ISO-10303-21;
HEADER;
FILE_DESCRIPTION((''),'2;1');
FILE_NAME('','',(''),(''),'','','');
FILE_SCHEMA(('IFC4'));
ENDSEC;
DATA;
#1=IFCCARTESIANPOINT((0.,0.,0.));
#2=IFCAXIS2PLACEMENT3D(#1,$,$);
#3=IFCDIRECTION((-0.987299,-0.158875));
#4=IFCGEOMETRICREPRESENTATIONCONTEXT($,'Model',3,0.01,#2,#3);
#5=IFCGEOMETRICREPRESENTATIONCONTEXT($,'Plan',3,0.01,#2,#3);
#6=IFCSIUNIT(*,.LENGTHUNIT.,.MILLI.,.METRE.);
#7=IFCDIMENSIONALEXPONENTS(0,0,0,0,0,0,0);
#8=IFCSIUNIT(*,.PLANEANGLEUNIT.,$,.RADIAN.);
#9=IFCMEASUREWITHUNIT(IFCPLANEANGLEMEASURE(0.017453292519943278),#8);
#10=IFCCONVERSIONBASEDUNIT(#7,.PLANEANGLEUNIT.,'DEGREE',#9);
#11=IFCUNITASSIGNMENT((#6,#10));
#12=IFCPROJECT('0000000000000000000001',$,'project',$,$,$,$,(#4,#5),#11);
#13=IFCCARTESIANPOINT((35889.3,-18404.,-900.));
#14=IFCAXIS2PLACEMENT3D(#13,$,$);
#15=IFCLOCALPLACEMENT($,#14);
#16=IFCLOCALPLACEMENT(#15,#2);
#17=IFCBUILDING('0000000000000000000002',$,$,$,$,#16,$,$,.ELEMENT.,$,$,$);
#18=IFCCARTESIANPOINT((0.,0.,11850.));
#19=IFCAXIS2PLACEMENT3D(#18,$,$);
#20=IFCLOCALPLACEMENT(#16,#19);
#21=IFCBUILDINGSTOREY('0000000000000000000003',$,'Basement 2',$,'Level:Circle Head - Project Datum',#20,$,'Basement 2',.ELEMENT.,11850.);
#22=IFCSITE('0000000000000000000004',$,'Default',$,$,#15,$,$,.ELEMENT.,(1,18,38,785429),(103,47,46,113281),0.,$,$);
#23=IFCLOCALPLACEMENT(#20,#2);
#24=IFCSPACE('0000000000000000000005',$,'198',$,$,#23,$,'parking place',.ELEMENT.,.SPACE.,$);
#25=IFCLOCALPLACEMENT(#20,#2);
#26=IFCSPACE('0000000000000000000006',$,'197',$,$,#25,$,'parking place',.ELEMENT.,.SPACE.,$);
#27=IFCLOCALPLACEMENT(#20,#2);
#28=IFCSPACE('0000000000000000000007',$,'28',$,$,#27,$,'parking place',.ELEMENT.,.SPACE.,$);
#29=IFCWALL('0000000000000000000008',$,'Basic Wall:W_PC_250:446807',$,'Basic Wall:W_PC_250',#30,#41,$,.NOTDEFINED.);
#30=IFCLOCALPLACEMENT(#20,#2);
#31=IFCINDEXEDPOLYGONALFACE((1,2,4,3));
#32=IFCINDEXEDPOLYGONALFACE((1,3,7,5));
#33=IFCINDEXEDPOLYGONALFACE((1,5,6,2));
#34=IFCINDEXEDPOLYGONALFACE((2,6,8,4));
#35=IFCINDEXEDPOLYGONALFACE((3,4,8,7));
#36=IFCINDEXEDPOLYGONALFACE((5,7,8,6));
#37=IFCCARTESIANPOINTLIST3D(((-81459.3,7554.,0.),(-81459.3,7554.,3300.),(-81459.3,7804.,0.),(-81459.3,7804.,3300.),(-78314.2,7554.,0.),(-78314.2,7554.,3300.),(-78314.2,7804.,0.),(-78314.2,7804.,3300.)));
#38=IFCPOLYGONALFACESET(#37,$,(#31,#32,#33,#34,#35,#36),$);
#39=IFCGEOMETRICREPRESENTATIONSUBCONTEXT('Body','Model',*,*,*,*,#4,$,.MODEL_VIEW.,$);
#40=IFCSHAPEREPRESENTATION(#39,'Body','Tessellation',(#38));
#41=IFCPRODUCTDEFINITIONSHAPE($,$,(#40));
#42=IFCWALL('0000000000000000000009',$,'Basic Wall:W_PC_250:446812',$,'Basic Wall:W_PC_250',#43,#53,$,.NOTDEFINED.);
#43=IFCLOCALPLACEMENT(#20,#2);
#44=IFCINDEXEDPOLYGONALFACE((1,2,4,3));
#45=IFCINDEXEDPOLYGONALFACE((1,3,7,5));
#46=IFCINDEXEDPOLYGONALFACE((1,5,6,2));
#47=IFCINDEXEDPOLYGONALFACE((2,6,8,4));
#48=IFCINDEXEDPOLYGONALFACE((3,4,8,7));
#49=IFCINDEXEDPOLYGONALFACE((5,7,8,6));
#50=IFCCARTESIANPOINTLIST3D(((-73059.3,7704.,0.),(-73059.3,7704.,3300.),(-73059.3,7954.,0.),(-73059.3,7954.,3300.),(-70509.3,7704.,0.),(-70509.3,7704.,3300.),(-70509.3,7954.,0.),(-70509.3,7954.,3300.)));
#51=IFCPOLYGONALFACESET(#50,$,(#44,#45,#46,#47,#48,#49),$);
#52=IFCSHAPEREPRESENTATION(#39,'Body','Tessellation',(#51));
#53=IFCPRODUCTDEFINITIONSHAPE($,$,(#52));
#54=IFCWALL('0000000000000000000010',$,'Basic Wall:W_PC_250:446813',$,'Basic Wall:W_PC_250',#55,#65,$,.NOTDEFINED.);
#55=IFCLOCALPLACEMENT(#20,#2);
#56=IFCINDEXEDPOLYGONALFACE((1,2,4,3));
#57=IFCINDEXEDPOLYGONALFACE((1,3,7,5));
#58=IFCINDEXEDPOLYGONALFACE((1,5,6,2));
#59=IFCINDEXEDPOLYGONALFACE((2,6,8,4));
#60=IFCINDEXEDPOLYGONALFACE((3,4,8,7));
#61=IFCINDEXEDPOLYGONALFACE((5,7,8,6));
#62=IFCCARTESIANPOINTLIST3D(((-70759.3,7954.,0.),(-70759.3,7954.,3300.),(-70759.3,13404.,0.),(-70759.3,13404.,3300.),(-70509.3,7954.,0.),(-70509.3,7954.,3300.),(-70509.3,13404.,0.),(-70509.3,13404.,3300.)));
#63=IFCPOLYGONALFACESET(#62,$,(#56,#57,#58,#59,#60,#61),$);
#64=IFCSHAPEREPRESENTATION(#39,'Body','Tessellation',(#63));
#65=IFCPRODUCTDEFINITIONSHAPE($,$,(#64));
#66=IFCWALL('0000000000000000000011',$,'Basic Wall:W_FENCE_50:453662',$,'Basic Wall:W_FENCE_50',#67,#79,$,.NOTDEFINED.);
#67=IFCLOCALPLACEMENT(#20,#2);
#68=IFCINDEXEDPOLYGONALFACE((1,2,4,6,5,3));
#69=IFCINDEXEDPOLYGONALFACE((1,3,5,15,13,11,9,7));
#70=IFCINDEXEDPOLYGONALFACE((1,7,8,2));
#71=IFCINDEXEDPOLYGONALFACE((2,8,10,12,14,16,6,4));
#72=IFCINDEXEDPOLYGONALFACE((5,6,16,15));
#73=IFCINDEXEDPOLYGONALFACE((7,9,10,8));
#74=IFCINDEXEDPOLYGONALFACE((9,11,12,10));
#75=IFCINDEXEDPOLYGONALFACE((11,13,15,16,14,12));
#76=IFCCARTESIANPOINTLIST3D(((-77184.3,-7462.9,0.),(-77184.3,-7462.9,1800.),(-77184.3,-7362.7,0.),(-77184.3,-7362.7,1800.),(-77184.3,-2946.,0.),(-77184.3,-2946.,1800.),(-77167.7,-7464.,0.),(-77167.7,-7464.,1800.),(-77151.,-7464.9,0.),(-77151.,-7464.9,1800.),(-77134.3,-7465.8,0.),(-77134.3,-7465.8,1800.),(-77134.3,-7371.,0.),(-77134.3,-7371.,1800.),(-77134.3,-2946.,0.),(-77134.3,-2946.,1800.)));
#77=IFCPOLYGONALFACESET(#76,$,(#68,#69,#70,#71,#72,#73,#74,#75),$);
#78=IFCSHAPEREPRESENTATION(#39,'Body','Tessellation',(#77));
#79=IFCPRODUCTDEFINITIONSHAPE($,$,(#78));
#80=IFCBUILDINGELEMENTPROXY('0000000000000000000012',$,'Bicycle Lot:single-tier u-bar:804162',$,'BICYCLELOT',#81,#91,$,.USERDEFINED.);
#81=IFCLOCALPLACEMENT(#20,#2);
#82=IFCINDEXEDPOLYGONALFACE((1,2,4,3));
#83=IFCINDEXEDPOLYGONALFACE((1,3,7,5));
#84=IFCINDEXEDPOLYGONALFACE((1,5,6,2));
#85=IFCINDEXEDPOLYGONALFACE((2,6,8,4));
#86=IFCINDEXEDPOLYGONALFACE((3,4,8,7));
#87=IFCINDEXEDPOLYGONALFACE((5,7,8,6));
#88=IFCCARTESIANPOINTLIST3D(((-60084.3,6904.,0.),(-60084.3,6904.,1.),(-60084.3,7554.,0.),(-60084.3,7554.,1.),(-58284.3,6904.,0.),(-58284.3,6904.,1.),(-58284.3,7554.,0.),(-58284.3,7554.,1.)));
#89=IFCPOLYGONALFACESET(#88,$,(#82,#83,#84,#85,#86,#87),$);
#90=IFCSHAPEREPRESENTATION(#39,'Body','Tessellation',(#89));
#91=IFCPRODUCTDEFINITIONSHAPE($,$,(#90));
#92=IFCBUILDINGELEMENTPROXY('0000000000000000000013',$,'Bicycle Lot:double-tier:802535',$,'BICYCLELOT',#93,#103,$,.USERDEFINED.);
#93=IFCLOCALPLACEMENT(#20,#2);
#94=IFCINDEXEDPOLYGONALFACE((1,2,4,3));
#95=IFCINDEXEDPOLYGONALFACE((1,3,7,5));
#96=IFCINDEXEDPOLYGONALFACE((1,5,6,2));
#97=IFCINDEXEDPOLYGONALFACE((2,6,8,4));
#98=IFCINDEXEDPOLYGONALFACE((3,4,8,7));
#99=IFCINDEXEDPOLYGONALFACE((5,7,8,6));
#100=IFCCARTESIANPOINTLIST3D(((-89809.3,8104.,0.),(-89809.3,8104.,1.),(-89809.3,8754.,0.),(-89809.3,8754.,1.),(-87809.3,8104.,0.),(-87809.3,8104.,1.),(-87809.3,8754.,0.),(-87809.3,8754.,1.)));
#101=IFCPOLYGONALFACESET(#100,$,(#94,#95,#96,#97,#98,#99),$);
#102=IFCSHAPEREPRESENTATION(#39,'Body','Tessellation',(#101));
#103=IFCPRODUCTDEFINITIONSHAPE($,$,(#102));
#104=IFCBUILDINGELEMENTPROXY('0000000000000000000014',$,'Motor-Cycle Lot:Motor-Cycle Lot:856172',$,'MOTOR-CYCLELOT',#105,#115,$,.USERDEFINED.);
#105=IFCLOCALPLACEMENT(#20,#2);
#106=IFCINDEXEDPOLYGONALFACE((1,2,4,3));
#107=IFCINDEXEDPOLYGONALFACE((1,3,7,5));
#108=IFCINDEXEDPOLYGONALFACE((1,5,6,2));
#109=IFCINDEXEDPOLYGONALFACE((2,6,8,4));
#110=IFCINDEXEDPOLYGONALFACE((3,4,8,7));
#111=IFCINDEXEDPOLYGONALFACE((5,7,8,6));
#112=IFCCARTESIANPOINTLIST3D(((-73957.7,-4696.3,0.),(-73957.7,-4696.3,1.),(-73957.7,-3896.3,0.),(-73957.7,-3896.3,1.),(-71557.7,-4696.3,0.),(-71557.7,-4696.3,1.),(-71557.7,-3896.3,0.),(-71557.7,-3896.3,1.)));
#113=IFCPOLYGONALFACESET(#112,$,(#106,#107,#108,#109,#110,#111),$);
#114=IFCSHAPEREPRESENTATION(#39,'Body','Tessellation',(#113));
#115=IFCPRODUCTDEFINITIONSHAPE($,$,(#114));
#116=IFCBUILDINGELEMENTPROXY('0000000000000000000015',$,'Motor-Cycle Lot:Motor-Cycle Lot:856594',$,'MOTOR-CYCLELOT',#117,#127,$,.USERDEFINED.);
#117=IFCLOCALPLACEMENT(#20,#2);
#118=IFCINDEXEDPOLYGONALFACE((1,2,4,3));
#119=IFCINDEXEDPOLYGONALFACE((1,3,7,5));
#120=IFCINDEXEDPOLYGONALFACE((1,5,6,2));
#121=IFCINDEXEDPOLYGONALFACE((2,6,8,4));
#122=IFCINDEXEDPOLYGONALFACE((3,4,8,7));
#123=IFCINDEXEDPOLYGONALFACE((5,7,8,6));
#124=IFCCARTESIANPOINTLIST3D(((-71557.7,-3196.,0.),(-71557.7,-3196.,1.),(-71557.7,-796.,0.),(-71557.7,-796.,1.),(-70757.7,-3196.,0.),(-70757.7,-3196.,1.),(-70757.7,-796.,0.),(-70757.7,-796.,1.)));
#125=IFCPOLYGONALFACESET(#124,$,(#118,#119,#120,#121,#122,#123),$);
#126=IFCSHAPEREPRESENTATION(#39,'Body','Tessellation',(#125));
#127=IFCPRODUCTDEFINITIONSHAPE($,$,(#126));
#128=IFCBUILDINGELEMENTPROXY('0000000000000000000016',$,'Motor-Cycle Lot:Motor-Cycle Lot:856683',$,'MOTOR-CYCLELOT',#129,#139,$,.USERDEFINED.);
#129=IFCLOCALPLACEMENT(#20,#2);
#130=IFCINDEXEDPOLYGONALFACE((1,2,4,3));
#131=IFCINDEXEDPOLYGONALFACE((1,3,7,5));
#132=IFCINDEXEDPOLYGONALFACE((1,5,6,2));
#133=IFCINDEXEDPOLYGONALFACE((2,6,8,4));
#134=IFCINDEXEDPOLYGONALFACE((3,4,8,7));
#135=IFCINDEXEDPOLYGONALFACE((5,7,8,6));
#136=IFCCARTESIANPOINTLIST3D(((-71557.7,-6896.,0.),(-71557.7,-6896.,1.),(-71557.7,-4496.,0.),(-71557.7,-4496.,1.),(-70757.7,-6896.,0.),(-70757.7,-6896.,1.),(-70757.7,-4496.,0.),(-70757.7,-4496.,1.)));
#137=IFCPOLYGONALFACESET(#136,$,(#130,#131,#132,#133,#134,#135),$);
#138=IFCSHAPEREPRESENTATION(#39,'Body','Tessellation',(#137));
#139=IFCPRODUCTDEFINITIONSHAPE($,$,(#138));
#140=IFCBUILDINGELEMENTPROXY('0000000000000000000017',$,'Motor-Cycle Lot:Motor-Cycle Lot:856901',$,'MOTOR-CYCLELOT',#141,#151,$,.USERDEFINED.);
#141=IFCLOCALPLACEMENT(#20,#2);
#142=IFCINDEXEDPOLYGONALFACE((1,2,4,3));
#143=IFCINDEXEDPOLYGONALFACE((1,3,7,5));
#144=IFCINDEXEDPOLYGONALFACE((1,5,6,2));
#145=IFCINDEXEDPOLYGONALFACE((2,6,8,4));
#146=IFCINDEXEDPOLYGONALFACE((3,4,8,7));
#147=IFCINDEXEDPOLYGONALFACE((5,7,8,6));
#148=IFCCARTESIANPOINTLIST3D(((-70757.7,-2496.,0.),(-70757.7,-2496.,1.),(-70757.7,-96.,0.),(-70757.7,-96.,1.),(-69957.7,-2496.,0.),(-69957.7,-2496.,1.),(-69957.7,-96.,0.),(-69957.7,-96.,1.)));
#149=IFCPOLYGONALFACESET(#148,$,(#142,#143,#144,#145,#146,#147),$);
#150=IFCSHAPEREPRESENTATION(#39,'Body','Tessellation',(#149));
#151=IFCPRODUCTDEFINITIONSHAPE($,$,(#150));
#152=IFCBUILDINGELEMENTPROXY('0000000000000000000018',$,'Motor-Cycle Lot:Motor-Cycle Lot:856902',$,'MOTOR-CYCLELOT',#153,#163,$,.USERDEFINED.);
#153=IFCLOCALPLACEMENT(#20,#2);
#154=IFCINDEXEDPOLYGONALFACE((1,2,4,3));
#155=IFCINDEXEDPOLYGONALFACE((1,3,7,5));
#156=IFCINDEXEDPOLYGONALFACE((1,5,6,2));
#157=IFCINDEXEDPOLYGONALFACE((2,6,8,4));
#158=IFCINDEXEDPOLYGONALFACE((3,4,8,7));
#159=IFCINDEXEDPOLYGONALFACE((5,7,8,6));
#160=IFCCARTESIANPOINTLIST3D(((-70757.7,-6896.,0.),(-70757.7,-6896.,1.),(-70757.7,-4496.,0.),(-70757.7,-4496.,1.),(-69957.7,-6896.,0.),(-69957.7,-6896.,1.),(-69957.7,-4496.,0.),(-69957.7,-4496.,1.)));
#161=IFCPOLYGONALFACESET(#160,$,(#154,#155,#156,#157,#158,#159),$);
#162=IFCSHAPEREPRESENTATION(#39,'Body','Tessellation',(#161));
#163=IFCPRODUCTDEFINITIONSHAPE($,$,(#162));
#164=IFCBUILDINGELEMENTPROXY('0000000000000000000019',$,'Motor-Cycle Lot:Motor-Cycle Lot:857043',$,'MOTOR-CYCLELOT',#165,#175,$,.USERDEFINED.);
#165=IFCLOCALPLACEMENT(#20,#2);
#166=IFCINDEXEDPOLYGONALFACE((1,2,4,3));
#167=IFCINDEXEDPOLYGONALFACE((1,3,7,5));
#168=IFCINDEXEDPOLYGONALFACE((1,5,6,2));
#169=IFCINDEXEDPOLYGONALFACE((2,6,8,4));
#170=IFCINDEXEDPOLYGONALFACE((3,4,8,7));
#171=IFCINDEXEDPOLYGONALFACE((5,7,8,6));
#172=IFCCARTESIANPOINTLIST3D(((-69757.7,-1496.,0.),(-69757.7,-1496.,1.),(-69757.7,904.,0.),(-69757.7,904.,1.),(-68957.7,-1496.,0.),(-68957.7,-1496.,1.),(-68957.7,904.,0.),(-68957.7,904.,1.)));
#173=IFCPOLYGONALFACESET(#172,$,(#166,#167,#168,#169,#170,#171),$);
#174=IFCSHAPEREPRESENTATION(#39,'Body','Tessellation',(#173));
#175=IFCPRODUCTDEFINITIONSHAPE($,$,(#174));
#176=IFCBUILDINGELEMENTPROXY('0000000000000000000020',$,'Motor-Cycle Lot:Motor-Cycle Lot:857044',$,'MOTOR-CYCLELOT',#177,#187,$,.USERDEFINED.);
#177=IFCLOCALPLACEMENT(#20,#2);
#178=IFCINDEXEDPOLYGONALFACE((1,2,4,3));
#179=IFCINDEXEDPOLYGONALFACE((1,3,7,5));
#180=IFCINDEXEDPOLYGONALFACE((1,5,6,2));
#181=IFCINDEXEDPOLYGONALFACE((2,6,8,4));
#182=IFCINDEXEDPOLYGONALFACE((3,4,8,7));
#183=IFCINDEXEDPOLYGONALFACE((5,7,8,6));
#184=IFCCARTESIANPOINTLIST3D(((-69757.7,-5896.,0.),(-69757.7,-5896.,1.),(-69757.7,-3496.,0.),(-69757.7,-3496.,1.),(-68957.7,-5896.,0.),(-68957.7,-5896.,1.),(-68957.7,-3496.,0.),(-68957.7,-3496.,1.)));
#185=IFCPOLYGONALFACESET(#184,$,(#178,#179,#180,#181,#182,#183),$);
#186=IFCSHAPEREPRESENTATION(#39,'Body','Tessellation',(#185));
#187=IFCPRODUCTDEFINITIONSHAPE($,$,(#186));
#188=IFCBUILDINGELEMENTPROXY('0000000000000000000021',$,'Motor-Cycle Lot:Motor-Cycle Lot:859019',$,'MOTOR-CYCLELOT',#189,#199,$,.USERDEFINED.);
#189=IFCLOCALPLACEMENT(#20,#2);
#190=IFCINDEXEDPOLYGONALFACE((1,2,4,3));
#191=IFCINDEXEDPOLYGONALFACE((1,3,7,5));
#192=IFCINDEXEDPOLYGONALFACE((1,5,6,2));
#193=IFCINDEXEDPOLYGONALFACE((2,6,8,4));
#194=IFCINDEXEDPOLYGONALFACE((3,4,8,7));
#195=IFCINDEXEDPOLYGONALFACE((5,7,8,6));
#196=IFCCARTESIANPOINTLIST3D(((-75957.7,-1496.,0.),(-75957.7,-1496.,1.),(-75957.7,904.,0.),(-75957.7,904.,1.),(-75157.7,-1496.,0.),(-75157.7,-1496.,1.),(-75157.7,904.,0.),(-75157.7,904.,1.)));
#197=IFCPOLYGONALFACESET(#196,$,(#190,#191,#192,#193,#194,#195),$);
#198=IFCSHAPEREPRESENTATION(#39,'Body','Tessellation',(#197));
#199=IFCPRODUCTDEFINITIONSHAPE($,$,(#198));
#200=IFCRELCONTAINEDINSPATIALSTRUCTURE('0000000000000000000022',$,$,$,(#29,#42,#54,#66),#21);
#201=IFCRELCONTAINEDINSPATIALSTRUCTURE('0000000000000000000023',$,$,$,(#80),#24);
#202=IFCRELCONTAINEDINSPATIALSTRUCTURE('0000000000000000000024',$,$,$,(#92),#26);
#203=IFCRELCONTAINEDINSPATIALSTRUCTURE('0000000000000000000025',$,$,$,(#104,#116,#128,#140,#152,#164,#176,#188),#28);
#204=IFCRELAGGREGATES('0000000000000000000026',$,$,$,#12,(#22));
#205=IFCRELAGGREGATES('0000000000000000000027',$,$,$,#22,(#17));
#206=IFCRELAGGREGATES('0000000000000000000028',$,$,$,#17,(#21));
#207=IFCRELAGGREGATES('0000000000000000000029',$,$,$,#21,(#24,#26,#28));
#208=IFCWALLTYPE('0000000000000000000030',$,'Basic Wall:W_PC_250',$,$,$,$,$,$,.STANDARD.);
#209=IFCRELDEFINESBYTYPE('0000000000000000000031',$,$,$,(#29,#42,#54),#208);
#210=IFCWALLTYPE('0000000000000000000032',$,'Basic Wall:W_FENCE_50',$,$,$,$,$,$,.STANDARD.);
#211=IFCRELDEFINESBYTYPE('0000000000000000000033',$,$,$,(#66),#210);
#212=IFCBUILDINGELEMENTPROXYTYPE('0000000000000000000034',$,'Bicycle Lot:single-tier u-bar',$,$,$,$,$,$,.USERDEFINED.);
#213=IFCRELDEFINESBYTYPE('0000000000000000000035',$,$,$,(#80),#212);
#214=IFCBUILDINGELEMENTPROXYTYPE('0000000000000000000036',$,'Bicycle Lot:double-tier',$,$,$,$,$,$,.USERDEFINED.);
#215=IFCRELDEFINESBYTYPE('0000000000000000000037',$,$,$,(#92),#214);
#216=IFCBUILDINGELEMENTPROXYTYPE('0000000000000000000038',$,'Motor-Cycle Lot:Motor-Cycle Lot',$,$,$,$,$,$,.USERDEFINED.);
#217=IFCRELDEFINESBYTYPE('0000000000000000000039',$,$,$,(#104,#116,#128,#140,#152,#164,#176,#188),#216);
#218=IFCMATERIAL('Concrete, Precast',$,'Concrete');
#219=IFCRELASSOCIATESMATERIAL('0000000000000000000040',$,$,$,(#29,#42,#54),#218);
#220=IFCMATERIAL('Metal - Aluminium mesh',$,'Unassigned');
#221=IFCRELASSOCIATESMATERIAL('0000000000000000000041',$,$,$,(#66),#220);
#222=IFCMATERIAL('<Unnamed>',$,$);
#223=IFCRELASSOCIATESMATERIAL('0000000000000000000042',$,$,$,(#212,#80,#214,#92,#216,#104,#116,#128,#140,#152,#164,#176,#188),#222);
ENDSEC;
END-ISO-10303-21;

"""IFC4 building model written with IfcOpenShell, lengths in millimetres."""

from ifc_helpers import new_model, entity, si_unit, converted_unit, direction, frame, origin, place, context, subcontext, project, spatial, line, arc, indexed_curve, outline, extrude, source, transform, mapped, material, type_object, type_shapes, element, save


model = new_model("IFC4")

# Units and contexts
model_context = context("Model", 3, precision=0.01, world=origin(), true_north=direction((-0.987299, -0.158875)))
plan_context = context("Plan", 3, precision=0.01, world=origin(), true_north=direction((-0.987299, -0.158875)))
body_context = subcontext(model_context, "Body", "Model", "MODEL_VIEW")
ifc_project = project(units=[si_unit("LENGTHUNIT", "METRE", prefix="MILLI"), converted_unit("PLANEANGLEUNIT", "DEGREE", entity("IfcPlaneAngleMeasure", 0.017453292519943278), si_unit("PLANEANGLEUNIT", "RADIAN"), dimensions=[0, 0, 0, 0, 0, 0, 0])], contexts=[model_context, plan_context])

# Site, building, storey
site_placement = place(None, frame((35889.3, -18404.0, -900.0)))
site = spatial("IfcSite", under=ifc_project, at=site_placement, Name="Default", CompositionType="ELEMENT", RefLatitude=(1, 18, 38, 785429), RefLongitude=(103, 47, 46, 113281), RefElevation=0.0)
building_placement = place(site_placement, origin())
building = spatial("IfcBuilding", under=site, at=building_placement, CompositionType="ELEMENT")
storey_placement = place(building_placement, frame((0.0, 0.0, 11850.0)))
storey = spatial("IfcBuildingStorey", under=building, at=storey_placement, Name="Basement 2", ObjectType="Level:Circle Head - Project Datum", LongName="Basement 2", CompositionType="ELEMENT", Elevation=11850.0)

# Shared definitions
ifc_material_1 = material(Name="Concrete, Precast", Category="Concrete")

# Walls
wall_type_1 = type_object("IfcWallType", Name="Basic Wall:W_PC_250", PredefinedType="STANDARD")
wall_1_placement = place(storey_placement, frame((-81459.3, 7679.0, 0.0)))
element("IfcWall", 1, at=wall_1_placement, inside=storey, type_object=wall_type_1, material=ifc_material_1, Name="Basic Wall:W_PC_250:446807", ObjectType="Basic Wall:W_PC_250", PredefinedType="NOTDEFINED", context=body_context, shape_type="SweptSolid", body=[
    extrude(outline(indexed_curve([(3145.2, 125.0), (0.0, 125.0), (0.0, -125.0), (3145.2, -125.0), (3145.2, 125.0)], self_intersect=False)), origin(), (0.0, 0.0, 1.0), 3300.0),
])
wall_2_placement = place(storey_placement, frame((-73059.3, 7829.0, 0.0)))
element("IfcWall", 2, at=wall_2_placement, inside=storey, type_object=wall_type_1, material=ifc_material_1, Name="Basic Wall:W_PC_250:446812", ObjectType="Basic Wall:W_PC_250", PredefinedType="NOTDEFINED", context=body_context, shape_type="SweptSolid", body=[
    extrude(outline(indexed_curve([(2550.0, 125.0), (0.0, 125.0), (0.0, -125.0), (2550.0, -125.0), (2550.0, 125.0)], self_intersect=False)), origin(), (0.0, 0.0, 1.0), 3300.0),
])
wall_3_placement = place(storey_placement, frame((-70634.3, 7954.0, 0.0), z_axis=(0.0, 0.0, 1.0), x_axis=(0.0, 1.0, 0.0)))
element("IfcWall", 3, at=wall_3_placement, inside=storey, type_object=wall_type_1, material=ifc_material_1, Name="Basic Wall:W_PC_250:446813", ObjectType="Basic Wall:W_PC_250", PredefinedType="NOTDEFINED", context=body_context, shape_type="SweptSolid", body=[
    extrude(outline(indexed_curve([(5450.0, 125.0), (0.0, 125.0), (0.0, -125.0), (5450.0, -125.0), (5450.0, 125.0)], self_intersect=False)), origin(), (0.0, 0.0, 1.0), 3300.0),
])
ifc_material_2 = material(Name="Metal - Aluminium mesh", Category="Unassigned")
wall_type_2 = type_object("IfcWallType", Name="Basic Wall:W_FENCE_50", PredefinedType="STANDARD")
wall_4_placement = place(storey_placement, frame((-77159.3, -7465.8, 0.0), z_axis=(0.0, 0.0, 1.0), x_axis=(0.0, 1.0, 0.0)))
element("IfcWall", 4, at=wall_4_placement, inside=storey, type_object=wall_type_2, material=ifc_material_2, Name="Basic Wall:W_FENCE_50:453662", ObjectType="Basic Wall:W_FENCE_50", PredefinedType="NOTDEFINED", context=body_context, shape_type="SweptSolid", body=[
    extrude(outline(indexed_curve([(4519.9, -25.0), (4519.9, 25.0), (103.1, 25.0), (2.9, 25.0), (1.4, 0.0), (0.0, -25.0), (94.9, -25.0)], segments=[line(1, 2, 3, 4), arc(4, 5, 6), line(6, 7, 1)], self_intersect=False)), origin(), (0.0, 0.0, 1.0), 1800.0),
])

# Shared definitions
space_1_placement = place(storey_placement, origin())
space_1 = spatial("IfcSpace", under=storey, at=space_1_placement, Name="198", LongName="parking place", CompositionType="ELEMENT", PredefinedType="SPACE")

# Building element proxy
ifc_material_3 = material(Name="<Unnamed>")
building_element_proxy_type_1 = type_object("IfcBuildingElementProxyType", Name="Bicycle Lot:single-tier u-bar", PredefinedType="USERDEFINED", material=ifc_material_3)
shared_shape_1 = source(origin(), body_context, "Body", "SweptSolid", [
    extrude(outline(indexed_curve([(-325.0, -900.0), (325.0, -900.0), (325.0, 900.0), (-325.0, 900.0), (-325.0, -900.0)], self_intersect=False)), frame((0.0, 0.0, 0.0), z_axis=(0.0, 0.0, 1.0), x_axis=(-1.0, 0.0, 0.0)), (0.0, 0.0, 1.0), 1.0),
])
type_shapes(building_element_proxy_type_1, [shared_shape_1])
proxy_1_placement = place(space_1_placement, frame((-59184.3, 7229.0, 0.0), z_axis=(0.0, 0.0, 1.0), x_axis=(0.0, 1.0, 0.0)))
element("IfcBuildingElementProxy", 5, at=proxy_1_placement, inside=space_1, type_object=building_element_proxy_type_1, material=ifc_material_3, Name="Bicycle Lot:single-tier u-bar:804162", ObjectType="BICYCLELOT", PredefinedType="USERDEFINED", context=body_context, shape_type="MappedRepresentation", body=[
    mapped(shared_shape_1, transform((0.0, 0.0, 0.0), scale=1.0)),
])

# Shared definitions
space_2_placement = place(storey_placement, origin())
space_2 = spatial("IfcSpace", under=storey, at=space_2_placement, Name="197", LongName="parking place", CompositionType="ELEMENT", PredefinedType="SPACE")

# Building element proxy
building_element_proxy_type_2 = type_object("IfcBuildingElementProxyType", Name="Bicycle Lot:double-tier", PredefinedType="USERDEFINED", material=ifc_material_3)
shared_shape_2 = source(origin(), body_context, "Body", "SweptSolid", [
    extrude(outline(indexed_curve([(-325.0, -1000.0), (325.0, -1000.0), (325.0, 1000.0), (-325.0, 1000.0), (-325.0, -1000.0)], self_intersect=False)), frame((0.0, 0.0, 0.0), z_axis=(0.0, 0.0, 1.0), x_axis=(-1.0, 0.0, 0.0)), (0.0, 0.0, 1.0), 1.0),
])
type_shapes(building_element_proxy_type_2, [shared_shape_2])
proxy_2_placement = place(space_2_placement, frame((-88809.3, 8429.0, 0.0), z_axis=(0.0, 0.0, 1.0), x_axis=(0.0, -1.0, 0.0)))
element("IfcBuildingElementProxy", 6, at=proxy_2_placement, inside=space_2, type_object=building_element_proxy_type_2, material=ifc_material_3, Name="Bicycle Lot:double-tier:802535", ObjectType="BICYCLELOT", PredefinedType="USERDEFINED", context=body_context, shape_type="MappedRepresentation", body=[
    mapped(shared_shape_2, transform((0.0, 0.0, 0.0), scale=1.0)),
])

# Shared definitions
space_3_placement = place(storey_placement, origin())
space_3 = spatial("IfcSpace", under=storey, at=space_3_placement, Name="28", LongName="parking place", CompositionType="ELEMENT", PredefinedType="SPACE")

# Building element proxies
building_element_proxy_type_3 = type_object("IfcBuildingElementProxyType", Name="Motor-Cycle Lot:Motor-Cycle Lot", PredefinedType="USERDEFINED", material=ifc_material_3)
shared_shape_3 = source(origin(), body_context, "Body", "SweptSolid", [
    extrude(outline(indexed_curve([(-400.0, -1200.0), (400.0, -1200.0), (400.0, 1200.0), (-400.0, 1200.0), (-400.0, -1200.0)], self_intersect=False)), frame((0.0, 0.0, 0.0), z_axis=(0.0, 0.0, 1.0), x_axis=(-1.0, 0.0, 0.0)), (0.0, 0.0, 1.0), 1.0),
])
type_shapes(building_element_proxy_type_3, [shared_shape_3])
for number, where, z_axis, x_axis, name in (
    (7, (-72757.7, -4296.3, 0.0), (0.0, 0.0, 1.0), (0.0, 1.0, 0.0), "Motor-Cycle Lot:Motor-Cycle Lot:856172"),
    (8, (-71157.7, -1996.0, 0.0), (0.0, 0.0, 1.0), (-1.0, 0.0, 0.0), "Motor-Cycle Lot:Motor-Cycle Lot:856594"),
    (9, (-71157.7, -5696.0, 0.0), (0.0, 0.0, 1.0), (-1.0, 0.0, 0.0), "Motor-Cycle Lot:Motor-Cycle Lot:856683"),
    (10, (-70357.7, -1296.0, 0.0), (0.0, 0.0, 1.0), (-1.0, 0.0, 0.0), "Motor-Cycle Lot:Motor-Cycle Lot:856901"),
    (11, (-70357.7, -5696.0, 0.0), (0.0, 0.0, 1.0), (-1.0, 0.0, 0.0), "Motor-Cycle Lot:Motor-Cycle Lot:856902"),
    (12, (-69357.7, -296.0, 0.0), (0.0, 0.0, 1.0), (-1.0, 0.0, 0.0), "Motor-Cycle Lot:Motor-Cycle Lot:857043"),
    (13, (-69357.7, -4696.0, 0.0), (0.0, 0.0, 1.0), (-1.0, 0.0, 0.0), "Motor-Cycle Lot:Motor-Cycle Lot:857044"),
    (14, (-75557.7, -296.0, 0.0), (0.0, 0.0, 1.0), (-1.0, 0.0, 0.0), "Motor-Cycle Lot:Motor-Cycle Lot:859019"),
):
    element("IfcBuildingElementProxy", number, at=place(space_3_placement, frame(where, z_axis=z_axis, x_axis=x_axis)), inside=space_3, type_object=building_element_proxy_type_3, material=ifc_material_3, Name=name, ObjectType="MOTOR-CYCLELOT", PredefinedType="USERDEFINED", context=body_context, shape_type="MappedRepresentation", body=[
        mapped(shared_shape_3, transform((0.0, 0.0, 0.0), scale=1.0)),
    ])

save(model, "model.ifc")
